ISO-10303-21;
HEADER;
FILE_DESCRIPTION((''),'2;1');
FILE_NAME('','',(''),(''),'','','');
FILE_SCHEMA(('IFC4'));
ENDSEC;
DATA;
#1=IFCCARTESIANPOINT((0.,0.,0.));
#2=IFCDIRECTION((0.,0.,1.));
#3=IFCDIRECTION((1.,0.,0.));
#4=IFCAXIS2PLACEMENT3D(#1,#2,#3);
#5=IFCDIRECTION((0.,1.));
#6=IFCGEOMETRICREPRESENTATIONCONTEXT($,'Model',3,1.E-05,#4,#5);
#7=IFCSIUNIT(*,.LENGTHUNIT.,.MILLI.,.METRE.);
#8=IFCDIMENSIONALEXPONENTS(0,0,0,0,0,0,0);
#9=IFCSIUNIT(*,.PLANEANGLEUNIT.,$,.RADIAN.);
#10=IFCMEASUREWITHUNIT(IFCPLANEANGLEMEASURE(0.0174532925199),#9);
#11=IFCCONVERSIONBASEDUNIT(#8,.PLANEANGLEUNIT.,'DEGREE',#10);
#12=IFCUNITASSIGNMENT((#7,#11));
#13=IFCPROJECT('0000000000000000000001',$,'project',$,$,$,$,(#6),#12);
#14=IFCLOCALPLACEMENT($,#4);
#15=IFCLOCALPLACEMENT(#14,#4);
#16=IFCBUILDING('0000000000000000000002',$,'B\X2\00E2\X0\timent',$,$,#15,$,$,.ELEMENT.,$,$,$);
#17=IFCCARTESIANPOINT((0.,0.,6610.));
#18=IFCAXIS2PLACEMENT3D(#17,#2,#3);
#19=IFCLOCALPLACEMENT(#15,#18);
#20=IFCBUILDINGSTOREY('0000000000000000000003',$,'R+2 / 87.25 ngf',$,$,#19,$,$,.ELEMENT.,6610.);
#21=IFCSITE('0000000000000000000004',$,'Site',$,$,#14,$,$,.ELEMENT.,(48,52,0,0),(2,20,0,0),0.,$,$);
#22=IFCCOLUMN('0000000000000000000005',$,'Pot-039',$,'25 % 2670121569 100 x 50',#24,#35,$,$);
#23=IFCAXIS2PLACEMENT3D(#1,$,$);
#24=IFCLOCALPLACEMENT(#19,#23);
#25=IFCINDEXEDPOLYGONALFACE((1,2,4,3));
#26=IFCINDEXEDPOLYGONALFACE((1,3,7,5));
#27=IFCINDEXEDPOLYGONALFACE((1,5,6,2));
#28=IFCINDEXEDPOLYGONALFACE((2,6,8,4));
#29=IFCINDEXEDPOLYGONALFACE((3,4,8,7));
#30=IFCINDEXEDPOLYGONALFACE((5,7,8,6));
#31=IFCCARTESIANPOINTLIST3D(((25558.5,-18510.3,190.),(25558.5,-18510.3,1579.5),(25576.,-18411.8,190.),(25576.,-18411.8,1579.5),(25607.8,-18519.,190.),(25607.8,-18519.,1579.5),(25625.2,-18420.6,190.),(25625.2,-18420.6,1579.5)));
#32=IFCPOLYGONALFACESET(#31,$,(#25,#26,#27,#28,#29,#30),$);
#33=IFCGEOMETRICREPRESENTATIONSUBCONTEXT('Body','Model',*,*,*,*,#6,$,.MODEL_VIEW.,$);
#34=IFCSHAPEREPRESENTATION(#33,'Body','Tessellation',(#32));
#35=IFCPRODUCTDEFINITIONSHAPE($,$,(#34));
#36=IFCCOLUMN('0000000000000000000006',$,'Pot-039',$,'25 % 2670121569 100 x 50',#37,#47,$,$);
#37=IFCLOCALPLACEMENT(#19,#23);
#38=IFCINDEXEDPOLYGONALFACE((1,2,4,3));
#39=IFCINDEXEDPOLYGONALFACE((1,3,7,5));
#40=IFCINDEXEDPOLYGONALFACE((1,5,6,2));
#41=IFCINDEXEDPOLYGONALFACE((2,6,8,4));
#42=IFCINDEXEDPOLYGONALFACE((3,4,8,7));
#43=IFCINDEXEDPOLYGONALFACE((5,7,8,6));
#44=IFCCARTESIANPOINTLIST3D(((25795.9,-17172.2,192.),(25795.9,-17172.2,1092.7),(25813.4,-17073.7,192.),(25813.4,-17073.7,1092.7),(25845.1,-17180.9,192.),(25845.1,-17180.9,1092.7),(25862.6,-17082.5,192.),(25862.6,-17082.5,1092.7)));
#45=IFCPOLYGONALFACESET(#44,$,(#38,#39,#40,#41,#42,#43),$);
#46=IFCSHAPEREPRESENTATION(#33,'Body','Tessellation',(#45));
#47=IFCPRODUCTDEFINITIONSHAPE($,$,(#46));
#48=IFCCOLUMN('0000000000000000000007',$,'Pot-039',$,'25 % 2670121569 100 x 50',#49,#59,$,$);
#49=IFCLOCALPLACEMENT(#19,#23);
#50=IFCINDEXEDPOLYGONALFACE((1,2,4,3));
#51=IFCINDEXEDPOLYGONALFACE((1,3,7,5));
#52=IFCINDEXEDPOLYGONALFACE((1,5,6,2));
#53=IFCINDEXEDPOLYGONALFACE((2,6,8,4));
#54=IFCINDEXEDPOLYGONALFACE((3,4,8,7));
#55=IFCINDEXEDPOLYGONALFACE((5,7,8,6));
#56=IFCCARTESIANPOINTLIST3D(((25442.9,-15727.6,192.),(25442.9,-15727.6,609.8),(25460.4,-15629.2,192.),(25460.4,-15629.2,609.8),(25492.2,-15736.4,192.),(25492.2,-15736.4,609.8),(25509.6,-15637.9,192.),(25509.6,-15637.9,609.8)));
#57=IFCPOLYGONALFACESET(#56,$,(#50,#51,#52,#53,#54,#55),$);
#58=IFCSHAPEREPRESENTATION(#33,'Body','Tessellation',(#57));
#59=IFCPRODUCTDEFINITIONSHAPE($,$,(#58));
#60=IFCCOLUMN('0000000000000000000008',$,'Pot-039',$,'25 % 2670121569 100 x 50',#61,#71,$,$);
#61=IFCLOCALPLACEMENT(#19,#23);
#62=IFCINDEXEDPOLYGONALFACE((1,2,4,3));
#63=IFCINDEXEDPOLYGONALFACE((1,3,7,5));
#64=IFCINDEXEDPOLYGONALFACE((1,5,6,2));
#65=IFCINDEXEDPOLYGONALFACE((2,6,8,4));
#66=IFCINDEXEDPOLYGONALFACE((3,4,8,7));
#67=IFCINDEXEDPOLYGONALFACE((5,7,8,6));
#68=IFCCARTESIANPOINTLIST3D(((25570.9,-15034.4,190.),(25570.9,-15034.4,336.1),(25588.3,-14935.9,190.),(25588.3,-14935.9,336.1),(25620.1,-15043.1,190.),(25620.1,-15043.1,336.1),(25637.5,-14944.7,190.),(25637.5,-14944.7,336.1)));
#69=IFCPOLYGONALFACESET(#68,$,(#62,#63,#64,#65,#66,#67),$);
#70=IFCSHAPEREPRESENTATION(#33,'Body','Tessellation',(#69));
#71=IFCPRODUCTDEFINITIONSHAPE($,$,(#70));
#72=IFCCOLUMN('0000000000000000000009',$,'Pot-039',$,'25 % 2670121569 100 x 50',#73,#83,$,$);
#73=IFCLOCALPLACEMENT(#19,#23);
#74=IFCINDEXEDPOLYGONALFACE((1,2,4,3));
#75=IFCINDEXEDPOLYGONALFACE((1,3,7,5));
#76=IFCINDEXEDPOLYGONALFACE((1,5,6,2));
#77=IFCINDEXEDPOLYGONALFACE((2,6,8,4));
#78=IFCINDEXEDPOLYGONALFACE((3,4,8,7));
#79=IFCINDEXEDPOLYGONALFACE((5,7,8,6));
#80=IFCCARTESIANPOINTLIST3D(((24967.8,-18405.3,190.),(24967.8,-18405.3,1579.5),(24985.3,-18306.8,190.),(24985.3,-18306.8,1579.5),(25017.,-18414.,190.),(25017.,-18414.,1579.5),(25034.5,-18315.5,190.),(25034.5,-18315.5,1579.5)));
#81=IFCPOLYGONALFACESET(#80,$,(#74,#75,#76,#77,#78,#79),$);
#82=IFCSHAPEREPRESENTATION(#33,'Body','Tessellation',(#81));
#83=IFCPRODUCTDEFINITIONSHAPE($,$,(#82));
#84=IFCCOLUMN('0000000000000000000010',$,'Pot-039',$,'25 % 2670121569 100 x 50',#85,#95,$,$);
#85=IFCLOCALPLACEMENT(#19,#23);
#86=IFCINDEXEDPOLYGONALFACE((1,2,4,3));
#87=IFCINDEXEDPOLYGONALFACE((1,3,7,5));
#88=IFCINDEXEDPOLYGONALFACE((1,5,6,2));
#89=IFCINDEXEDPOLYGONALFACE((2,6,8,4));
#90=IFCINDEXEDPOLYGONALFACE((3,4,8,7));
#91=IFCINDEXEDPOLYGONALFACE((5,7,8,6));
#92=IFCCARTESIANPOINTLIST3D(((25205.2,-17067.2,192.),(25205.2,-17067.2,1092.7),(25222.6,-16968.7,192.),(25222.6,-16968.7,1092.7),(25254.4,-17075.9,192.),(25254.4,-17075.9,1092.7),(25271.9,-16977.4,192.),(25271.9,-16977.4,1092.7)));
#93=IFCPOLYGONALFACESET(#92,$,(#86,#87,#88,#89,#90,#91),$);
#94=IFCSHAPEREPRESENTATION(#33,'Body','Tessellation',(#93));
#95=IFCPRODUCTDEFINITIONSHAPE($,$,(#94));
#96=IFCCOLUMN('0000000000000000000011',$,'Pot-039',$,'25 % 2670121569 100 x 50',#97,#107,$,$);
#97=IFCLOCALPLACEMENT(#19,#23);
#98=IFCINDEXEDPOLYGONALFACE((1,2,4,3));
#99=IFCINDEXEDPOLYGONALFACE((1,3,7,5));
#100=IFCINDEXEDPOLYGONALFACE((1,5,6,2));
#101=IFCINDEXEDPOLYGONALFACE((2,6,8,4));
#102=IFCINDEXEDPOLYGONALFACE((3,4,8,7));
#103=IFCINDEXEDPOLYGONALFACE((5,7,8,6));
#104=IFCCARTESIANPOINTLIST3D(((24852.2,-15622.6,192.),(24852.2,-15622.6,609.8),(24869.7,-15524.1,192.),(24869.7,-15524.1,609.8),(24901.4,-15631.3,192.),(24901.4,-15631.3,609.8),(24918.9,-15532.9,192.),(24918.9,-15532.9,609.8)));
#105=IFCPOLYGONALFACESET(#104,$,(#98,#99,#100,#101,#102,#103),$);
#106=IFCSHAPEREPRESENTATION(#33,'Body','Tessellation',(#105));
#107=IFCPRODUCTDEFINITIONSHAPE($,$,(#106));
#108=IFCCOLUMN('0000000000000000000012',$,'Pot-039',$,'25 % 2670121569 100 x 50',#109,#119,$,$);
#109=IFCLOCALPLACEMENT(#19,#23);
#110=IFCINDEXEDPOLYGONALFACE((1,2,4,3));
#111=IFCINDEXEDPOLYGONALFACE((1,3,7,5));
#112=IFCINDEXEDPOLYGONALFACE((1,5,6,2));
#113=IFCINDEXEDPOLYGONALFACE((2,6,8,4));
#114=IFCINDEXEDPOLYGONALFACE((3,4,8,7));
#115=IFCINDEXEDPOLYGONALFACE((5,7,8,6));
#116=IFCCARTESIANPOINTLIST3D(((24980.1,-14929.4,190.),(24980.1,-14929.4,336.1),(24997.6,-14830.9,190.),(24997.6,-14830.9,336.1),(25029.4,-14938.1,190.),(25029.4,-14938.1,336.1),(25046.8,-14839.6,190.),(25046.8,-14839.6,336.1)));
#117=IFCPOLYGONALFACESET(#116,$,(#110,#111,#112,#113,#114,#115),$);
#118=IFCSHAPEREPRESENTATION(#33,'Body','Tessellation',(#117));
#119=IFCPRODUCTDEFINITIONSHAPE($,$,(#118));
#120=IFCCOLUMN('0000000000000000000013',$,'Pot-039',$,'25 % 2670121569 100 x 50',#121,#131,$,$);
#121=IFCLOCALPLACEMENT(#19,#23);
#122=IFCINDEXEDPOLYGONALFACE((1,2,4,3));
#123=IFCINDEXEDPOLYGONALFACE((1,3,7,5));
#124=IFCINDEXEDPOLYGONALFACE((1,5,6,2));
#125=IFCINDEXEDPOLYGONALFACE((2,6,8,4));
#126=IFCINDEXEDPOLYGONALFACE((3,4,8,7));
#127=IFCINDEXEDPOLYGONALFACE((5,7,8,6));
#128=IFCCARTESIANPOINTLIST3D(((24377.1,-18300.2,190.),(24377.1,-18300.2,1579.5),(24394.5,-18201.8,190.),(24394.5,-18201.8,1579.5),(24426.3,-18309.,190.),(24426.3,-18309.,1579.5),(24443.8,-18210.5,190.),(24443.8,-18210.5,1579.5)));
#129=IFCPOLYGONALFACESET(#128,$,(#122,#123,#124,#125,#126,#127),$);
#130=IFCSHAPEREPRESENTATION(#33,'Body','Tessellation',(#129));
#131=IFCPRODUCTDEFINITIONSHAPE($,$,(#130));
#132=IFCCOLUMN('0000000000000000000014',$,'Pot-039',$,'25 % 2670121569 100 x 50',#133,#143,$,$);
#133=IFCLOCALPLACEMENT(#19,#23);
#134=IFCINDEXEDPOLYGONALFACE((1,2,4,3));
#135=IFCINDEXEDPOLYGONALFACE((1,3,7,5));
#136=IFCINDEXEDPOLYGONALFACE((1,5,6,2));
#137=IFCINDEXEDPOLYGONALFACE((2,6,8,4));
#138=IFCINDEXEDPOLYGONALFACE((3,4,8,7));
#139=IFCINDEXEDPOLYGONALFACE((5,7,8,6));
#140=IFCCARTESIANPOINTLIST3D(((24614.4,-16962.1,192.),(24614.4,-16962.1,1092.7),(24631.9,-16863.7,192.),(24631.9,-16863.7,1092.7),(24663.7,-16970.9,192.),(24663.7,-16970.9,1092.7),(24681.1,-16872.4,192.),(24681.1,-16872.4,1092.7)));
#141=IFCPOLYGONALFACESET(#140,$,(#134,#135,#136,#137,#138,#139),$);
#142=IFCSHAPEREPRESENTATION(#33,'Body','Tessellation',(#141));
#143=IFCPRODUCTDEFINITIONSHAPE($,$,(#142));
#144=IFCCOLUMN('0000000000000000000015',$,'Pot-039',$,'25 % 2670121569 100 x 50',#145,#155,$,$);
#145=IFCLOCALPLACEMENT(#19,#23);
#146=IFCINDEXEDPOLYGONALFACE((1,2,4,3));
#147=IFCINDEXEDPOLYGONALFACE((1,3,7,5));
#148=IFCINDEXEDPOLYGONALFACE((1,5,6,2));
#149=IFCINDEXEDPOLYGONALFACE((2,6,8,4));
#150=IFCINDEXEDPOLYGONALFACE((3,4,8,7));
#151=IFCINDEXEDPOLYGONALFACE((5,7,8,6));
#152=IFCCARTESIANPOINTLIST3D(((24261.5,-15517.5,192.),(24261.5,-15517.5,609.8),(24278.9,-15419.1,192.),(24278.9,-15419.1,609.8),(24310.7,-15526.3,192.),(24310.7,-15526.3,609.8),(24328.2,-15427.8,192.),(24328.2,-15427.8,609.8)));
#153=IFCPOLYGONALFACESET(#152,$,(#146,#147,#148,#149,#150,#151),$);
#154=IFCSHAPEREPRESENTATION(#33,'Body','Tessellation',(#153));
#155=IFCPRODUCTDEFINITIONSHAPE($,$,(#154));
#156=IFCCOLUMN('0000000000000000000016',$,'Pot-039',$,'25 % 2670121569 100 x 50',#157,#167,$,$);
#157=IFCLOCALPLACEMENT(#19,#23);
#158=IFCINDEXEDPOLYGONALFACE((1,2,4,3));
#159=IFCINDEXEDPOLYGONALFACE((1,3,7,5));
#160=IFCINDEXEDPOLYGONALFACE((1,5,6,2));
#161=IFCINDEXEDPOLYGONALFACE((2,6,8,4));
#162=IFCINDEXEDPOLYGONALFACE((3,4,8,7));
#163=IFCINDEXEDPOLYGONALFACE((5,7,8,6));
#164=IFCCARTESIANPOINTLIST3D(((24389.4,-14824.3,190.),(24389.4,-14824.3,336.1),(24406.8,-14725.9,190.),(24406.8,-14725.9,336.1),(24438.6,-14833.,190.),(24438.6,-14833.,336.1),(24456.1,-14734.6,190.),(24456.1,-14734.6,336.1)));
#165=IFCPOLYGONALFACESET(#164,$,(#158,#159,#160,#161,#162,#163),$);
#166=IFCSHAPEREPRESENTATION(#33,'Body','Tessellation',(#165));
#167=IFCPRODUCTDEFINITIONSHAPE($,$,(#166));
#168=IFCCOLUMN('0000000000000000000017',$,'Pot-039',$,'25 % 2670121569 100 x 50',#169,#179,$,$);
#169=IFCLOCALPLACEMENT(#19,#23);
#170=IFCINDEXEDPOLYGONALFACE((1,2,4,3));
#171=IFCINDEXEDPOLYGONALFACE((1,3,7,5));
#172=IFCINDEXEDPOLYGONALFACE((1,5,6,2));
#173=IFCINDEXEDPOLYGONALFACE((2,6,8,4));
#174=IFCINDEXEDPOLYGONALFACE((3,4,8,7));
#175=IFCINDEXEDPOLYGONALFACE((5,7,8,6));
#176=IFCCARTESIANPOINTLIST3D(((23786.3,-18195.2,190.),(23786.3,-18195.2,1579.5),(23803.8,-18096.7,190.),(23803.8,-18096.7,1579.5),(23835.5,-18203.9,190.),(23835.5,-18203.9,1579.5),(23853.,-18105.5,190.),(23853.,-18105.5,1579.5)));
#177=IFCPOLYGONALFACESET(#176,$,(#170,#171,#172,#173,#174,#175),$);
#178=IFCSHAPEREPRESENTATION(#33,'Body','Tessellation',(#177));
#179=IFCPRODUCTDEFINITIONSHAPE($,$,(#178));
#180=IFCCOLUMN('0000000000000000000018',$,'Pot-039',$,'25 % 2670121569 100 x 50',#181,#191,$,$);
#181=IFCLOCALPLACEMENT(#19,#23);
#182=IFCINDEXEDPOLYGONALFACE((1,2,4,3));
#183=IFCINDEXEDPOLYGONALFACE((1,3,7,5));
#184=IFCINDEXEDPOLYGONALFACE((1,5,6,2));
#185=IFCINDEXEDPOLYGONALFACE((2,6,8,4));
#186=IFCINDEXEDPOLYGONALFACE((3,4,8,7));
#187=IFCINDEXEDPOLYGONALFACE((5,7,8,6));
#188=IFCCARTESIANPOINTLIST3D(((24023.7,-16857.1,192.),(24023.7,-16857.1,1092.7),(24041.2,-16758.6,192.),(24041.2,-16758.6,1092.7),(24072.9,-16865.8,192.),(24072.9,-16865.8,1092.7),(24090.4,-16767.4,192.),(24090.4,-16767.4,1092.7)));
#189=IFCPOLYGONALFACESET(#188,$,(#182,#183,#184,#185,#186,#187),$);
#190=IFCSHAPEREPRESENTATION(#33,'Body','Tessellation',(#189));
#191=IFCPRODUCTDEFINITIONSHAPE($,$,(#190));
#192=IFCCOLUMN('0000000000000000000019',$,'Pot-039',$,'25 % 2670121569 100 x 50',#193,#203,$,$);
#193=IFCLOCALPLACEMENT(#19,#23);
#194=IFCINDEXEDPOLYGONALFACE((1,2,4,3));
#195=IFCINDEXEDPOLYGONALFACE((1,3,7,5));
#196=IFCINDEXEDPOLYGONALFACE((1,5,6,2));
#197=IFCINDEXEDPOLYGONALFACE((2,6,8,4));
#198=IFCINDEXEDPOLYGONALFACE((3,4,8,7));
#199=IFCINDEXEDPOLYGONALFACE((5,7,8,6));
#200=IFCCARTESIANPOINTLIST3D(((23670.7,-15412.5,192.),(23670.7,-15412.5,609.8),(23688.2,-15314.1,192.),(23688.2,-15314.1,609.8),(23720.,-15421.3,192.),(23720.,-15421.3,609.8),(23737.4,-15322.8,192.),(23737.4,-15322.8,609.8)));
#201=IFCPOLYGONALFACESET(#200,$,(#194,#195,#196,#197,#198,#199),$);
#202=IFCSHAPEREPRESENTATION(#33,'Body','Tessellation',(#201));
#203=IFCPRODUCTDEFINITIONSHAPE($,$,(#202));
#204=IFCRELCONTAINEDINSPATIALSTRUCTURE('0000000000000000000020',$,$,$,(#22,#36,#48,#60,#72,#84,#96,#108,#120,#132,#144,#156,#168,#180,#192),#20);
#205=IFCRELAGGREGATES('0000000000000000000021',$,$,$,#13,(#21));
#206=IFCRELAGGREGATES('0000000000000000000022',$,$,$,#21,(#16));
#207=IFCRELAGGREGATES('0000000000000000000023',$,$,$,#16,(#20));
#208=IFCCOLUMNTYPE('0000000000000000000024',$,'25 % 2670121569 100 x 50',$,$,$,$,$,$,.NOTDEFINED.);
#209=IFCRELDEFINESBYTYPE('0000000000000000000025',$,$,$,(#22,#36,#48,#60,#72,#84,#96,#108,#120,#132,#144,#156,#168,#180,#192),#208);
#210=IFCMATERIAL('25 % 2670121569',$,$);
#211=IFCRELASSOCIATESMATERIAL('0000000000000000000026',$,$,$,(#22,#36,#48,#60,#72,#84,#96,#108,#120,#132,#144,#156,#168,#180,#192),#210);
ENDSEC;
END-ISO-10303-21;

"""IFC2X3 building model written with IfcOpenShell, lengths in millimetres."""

from ifc_helpers import new_model, entity, si_unit, converted_unit, direction, frame, origin_with_axes, origin_2d_with_axis, place, context, subcontext, project, spatial, rectangle, extrude, material, type_object, element, save


model = new_model("IFC2X3")

# Units and contexts
model_context = context("Model", 3, precision=1e-05, world=origin_with_axes(), true_north=direction((0.0, 1.0)))
body_context = subcontext(model_context, "Body", "Model", "MODEL_VIEW")
ifc_project = project(units=[si_unit("LENGTHUNIT", "METRE", prefix="MILLI"), converted_unit("PLANEANGLEUNIT", "DEGREE", entity("IfcPlaneAngleMeasure", 0.0174532925199), si_unit("PLANEANGLEUNIT", "RADIAN"), dimensions=[0, 0, 0, 0, 0, 0, 0])], contexts=[model_context])

# Site, building, storey
site_placement = place(None, origin_with_axes())
site = spatial("IfcSite", under=ifc_project, at=site_placement, Name="Site", CompositionType="ELEMENT", RefLatitude=(48, 52, 0, 0), RefLongitude=(2, 20, 0, 0), RefElevation=0.0)
building_placement = place(site_placement, origin_with_axes())
building = spatial("IfcBuilding", under=site, at=building_placement, Name="Bâtiment", CompositionType="ELEMENT")
storey_placement = place(building_placement, frame((0.0, 0.0, 6610.0), z_axis=(0.0, 0.0, 1.0), x_axis=(1.0, 0.0, 0.0)))
storey = spatial("IfcBuildingStorey", under=building, at=storey_placement, Name="R+2 / 87.25 ngf", CompositionType="ELEMENT", Elevation=6610.0)

# Columns
ifc_material = material(Name="25 % 2670121569")
column_type = type_object("IfcColumnType", Name="25 % 2670121569 100 x 50", PredefinedType="NOTDEFINED")
column_1_placement = place(storey_placement, frame((25591.9, -18465.4, 190.0), z_axis=(0.0, 0.0, 1.0), x_axis=(0.17478, 0.984607, 0.0)))
element("IfcColumn", 1, at=column_1_placement, inside=storey, type_object=column_type, material=ifc_material, Name="Pot-039", ObjectType="25 % 2670121569 100 x 50", context=body_context, shape_type="SweptSolid", body=[
    extrude(rectangle(XDim=100.0, YDim=50.0, at=origin_2d_with_axis()), origin_with_axes(), (0.0, 0.0, 1.0), 1389.5),
])
column_2_placement = place(storey_placement, frame((25829.2, -17127.3, 192.0), z_axis=(0.0, 0.0, 1.0), x_axis=(0.17478, 0.984607, 0.0)))
element("IfcColumn", 2, at=column_2_placement, inside=storey, type_object=column_type, material=ifc_material, Name="Pot-039", ObjectType="25 % 2670121569 100 x 50", context=body_context, shape_type="SweptSolid", body=[
    extrude(rectangle(XDim=100.0, YDim=50.0, at=origin_2d_with_axis()), origin_with_axes(), (0.0, 0.0, 1.0), 900.7),
])
column_3_placement = place(storey_placement, frame((25476.3, -15682.8, 192.0), z_axis=(0.0, 0.0, 1.0), x_axis=(0.17478, 0.984607, 0.0)))
element("IfcColumn", 3, at=column_3_placement, inside=storey, type_object=column_type, material=ifc_material, Name="Pot-039", ObjectType="25 % 2670121569 100 x 50", context=body_context, shape_type="SweptSolid", body=[
    extrude(rectangle(XDim=100.0, YDim=50.0, at=origin_2d_with_axis()), origin_with_axes(), (0.0, 0.0, 1.0), 417.8),
])
column_4_placement = place(storey_placement, frame((25604.2, -14989.5, 190.0), z_axis=(0.0, 0.0, 1.0), x_axis=(0.174407, 0.984674, 0.0)))
element("IfcColumn", 4, at=column_4_placement, inside=storey, type_object=column_type, material=ifc_material, Name="Pot-039", ObjectType="25 % 2670121569 100 x 50", context=body_context, shape_type="SweptSolid", body=[
    extrude(rectangle(XDim=100.0, YDim=50.0, at=origin_2d_with_axis()), origin_with_axes(), (0.0, 0.0, 1.0), 146.1),
])
column_5_placement = place(storey_placement, frame((25001.1, -18360.4, 190.0), z_axis=(0.0, 0.0, 1.0), x_axis=(0.17478, 0.984607, 0.0)))
element("IfcColumn", 5, at=column_5_placement, inside=storey, type_object=column_type, material=ifc_material, Name="Pot-039", ObjectType="25 % 2670121569 100 x 50", context=body_context, shape_type="SweptSolid", body=[
    extrude(rectangle(XDim=100.0, YDim=50.0, at=origin_2d_with_axis()), origin_with_axes(), (0.0, 0.0, 1.0), 1389.5),
])
column_6_placement = place(storey_placement, frame((25238.5, -17022.3, 192.0), z_axis=(0.0, 0.0, 1.0), x_axis=(0.17478, 0.984607, 0.0)))
element("IfcColumn", 6, at=column_6_placement, inside=storey, type_object=column_type, material=ifc_material, Name="Pot-039", ObjectType="25 % 2670121569 100 x 50", context=body_context, shape_type="SweptSolid", body=[
    extrude(rectangle(XDim=100.0, YDim=50.0, at=origin_2d_with_axis()), origin_with_axes(), (0.0, 0.0, 1.0), 900.7),
])
column_7_placement = place(storey_placement, frame((24885.5, -15577.7, 192.0), z_axis=(0.0, 0.0, 1.0), x_axis=(0.17478, 0.984607, 0.0)))
element("IfcColumn", 7, at=column_7_placement, inside=storey, type_object=column_type, material=ifc_material, Name="Pot-039", ObjectType="25 % 2670121569 100 x 50", context=body_context, shape_type="SweptSolid", body=[
    extrude(rectangle(XDim=100.0, YDim=50.0, at=origin_2d_with_axis()), origin_with_axes(), (0.0, 0.0, 1.0), 417.8),
])
column_8_placement = place(storey_placement, frame((25013.5, -14884.5, 190.0), z_axis=(0.0, 0.0, 1.0), x_axis=(0.174407, 0.984674, 0.0)))
element("IfcColumn", 8, at=column_8_placement, inside=storey, type_object=column_type, material=ifc_material, Name="Pot-039", ObjectType="25 % 2670121569 100 x 50", context=body_context, shape_type="SweptSolid", body=[
    extrude(rectangle(XDim=100.0, YDim=50.0, at=origin_2d_with_axis()), origin_with_axes(), (0.0, 0.0, 1.0), 146.1),
])
column_9_placement = place(storey_placement, frame((24410.4, -18255.4, 190.0), z_axis=(0.0, 0.0, 1.0), x_axis=(0.17478, 0.984607, 0.0)))
element("IfcColumn", 9, at=column_9_placement, inside=storey, type_object=column_type, material=ifc_material, Name="Pot-039", ObjectType="25 % 2670121569 100 x 50", context=body_context, shape_type="SweptSolid", body=[
    extrude(rectangle(XDim=100.0, YDim=50.0, at=origin_2d_with_axis()), origin_with_axes(), (0.0, 0.0, 1.0), 1389.5),
])
column_10_placement = place(storey_placement, frame((24647.8, -16917.3, 192.0), z_axis=(0.0, 0.0, 1.0), x_axis=(0.17478, 0.984607, 0.0)))
element("IfcColumn", 10, at=column_10_placement, inside=storey, type_object=column_type, material=ifc_material, Name="Pot-039", ObjectType="25 % 2670121569 100 x 50", context=body_context, shape_type="SweptSolid", body=[
    extrude(rectangle(XDim=100.0, YDim=50.0, at=origin_2d_with_axis()), origin_with_axes(), (0.0, 0.0, 1.0), 900.7),
])
column_11_placement = place(storey_placement, frame((24294.8, -15472.7, 192.0), z_axis=(0.0, 0.0, 1.0), x_axis=(0.17478, 0.984607, 0.0)))
element("IfcColumn", 11, at=column_11_placement, inside=storey, type_object=column_type, material=ifc_material, Name="Pot-039", ObjectType="25 % 2670121569 100 x 50", context=body_context, shape_type="SweptSolid", body=[
    extrude(rectangle(XDim=100.0, YDim=50.0, at=origin_2d_with_axis()), origin_with_axes(), (0.0, 0.0, 1.0), 417.8),
])
column_12_placement = place(storey_placement, frame((24422.7, -14779.5, 190.0), z_axis=(0.0, 0.0, 1.0), x_axis=(0.174407, 0.984674, 0.0)))
element("IfcColumn", 12, at=column_12_placement, inside=storey, type_object=column_type, material=ifc_material, Name="Pot-039", ObjectType="25 % 2670121569 100 x 50", context=body_context, shape_type="SweptSolid", body=[
    extrude(rectangle(XDim=100.0, YDim=50.0, at=origin_2d_with_axis()), origin_with_axes(), (0.0, 0.0, 1.0), 146.1),
])
column_13_placement = place(storey_placement, frame((23819.7, -18150.3, 190.0), z_axis=(0.0, 0.0, 1.0), x_axis=(0.17478, 0.984607, 0.0)))
element("IfcColumn", 13, at=column_13_placement, inside=storey, type_object=column_type, material=ifc_material, Name="Pot-039", ObjectType="25 % 2670121569 100 x 50", context=body_context, shape_type="SweptSolid", body=[
    extrude(rectangle(XDim=100.0, YDim=50.0, at=origin_2d_with_axis()), origin_with_axes(), (0.0, 0.0, 1.0), 1389.5),
])
column_14_placement = place(storey_placement, frame((24057.0, -16812.2, 192.0), z_axis=(0.0, 0.0, 1.0), x_axis=(0.17478, 0.984607, 0.0)))
element("IfcColumn", 14, at=column_14_placement, inside=storey, type_object=column_type, material=ifc_material, Name="Pot-039", ObjectType="25 % 2670121569 100 x 50", context=body_context, shape_type="SweptSolid", body=[
    extrude(rectangle(XDim=100.0, YDim=50.0, at=origin_2d_with_axis()), origin_with_axes(), (0.0, 0.0, 1.0), 900.7),
])
column_15_placement = place(storey_placement, frame((23704.1, -15367.7, 192.0), z_axis=(0.0, 0.0, 1.0), x_axis=(0.17478, 0.984607, 0.0)))
element("IfcColumn", 15, at=column_15_placement, inside=storey, type_object=column_type, material=ifc_material, Name="Pot-039", ObjectType="25 % 2670121569 100 x 50", context=body_context, shape_type="SweptSolid", body=[
    extrude(rectangle(XDim=100.0, YDim=50.0, at=origin_2d_with_axis()), origin_with_axes(), (0.0, 0.0, 1.0), 417.8),
])

save(model, "model.ifc")
